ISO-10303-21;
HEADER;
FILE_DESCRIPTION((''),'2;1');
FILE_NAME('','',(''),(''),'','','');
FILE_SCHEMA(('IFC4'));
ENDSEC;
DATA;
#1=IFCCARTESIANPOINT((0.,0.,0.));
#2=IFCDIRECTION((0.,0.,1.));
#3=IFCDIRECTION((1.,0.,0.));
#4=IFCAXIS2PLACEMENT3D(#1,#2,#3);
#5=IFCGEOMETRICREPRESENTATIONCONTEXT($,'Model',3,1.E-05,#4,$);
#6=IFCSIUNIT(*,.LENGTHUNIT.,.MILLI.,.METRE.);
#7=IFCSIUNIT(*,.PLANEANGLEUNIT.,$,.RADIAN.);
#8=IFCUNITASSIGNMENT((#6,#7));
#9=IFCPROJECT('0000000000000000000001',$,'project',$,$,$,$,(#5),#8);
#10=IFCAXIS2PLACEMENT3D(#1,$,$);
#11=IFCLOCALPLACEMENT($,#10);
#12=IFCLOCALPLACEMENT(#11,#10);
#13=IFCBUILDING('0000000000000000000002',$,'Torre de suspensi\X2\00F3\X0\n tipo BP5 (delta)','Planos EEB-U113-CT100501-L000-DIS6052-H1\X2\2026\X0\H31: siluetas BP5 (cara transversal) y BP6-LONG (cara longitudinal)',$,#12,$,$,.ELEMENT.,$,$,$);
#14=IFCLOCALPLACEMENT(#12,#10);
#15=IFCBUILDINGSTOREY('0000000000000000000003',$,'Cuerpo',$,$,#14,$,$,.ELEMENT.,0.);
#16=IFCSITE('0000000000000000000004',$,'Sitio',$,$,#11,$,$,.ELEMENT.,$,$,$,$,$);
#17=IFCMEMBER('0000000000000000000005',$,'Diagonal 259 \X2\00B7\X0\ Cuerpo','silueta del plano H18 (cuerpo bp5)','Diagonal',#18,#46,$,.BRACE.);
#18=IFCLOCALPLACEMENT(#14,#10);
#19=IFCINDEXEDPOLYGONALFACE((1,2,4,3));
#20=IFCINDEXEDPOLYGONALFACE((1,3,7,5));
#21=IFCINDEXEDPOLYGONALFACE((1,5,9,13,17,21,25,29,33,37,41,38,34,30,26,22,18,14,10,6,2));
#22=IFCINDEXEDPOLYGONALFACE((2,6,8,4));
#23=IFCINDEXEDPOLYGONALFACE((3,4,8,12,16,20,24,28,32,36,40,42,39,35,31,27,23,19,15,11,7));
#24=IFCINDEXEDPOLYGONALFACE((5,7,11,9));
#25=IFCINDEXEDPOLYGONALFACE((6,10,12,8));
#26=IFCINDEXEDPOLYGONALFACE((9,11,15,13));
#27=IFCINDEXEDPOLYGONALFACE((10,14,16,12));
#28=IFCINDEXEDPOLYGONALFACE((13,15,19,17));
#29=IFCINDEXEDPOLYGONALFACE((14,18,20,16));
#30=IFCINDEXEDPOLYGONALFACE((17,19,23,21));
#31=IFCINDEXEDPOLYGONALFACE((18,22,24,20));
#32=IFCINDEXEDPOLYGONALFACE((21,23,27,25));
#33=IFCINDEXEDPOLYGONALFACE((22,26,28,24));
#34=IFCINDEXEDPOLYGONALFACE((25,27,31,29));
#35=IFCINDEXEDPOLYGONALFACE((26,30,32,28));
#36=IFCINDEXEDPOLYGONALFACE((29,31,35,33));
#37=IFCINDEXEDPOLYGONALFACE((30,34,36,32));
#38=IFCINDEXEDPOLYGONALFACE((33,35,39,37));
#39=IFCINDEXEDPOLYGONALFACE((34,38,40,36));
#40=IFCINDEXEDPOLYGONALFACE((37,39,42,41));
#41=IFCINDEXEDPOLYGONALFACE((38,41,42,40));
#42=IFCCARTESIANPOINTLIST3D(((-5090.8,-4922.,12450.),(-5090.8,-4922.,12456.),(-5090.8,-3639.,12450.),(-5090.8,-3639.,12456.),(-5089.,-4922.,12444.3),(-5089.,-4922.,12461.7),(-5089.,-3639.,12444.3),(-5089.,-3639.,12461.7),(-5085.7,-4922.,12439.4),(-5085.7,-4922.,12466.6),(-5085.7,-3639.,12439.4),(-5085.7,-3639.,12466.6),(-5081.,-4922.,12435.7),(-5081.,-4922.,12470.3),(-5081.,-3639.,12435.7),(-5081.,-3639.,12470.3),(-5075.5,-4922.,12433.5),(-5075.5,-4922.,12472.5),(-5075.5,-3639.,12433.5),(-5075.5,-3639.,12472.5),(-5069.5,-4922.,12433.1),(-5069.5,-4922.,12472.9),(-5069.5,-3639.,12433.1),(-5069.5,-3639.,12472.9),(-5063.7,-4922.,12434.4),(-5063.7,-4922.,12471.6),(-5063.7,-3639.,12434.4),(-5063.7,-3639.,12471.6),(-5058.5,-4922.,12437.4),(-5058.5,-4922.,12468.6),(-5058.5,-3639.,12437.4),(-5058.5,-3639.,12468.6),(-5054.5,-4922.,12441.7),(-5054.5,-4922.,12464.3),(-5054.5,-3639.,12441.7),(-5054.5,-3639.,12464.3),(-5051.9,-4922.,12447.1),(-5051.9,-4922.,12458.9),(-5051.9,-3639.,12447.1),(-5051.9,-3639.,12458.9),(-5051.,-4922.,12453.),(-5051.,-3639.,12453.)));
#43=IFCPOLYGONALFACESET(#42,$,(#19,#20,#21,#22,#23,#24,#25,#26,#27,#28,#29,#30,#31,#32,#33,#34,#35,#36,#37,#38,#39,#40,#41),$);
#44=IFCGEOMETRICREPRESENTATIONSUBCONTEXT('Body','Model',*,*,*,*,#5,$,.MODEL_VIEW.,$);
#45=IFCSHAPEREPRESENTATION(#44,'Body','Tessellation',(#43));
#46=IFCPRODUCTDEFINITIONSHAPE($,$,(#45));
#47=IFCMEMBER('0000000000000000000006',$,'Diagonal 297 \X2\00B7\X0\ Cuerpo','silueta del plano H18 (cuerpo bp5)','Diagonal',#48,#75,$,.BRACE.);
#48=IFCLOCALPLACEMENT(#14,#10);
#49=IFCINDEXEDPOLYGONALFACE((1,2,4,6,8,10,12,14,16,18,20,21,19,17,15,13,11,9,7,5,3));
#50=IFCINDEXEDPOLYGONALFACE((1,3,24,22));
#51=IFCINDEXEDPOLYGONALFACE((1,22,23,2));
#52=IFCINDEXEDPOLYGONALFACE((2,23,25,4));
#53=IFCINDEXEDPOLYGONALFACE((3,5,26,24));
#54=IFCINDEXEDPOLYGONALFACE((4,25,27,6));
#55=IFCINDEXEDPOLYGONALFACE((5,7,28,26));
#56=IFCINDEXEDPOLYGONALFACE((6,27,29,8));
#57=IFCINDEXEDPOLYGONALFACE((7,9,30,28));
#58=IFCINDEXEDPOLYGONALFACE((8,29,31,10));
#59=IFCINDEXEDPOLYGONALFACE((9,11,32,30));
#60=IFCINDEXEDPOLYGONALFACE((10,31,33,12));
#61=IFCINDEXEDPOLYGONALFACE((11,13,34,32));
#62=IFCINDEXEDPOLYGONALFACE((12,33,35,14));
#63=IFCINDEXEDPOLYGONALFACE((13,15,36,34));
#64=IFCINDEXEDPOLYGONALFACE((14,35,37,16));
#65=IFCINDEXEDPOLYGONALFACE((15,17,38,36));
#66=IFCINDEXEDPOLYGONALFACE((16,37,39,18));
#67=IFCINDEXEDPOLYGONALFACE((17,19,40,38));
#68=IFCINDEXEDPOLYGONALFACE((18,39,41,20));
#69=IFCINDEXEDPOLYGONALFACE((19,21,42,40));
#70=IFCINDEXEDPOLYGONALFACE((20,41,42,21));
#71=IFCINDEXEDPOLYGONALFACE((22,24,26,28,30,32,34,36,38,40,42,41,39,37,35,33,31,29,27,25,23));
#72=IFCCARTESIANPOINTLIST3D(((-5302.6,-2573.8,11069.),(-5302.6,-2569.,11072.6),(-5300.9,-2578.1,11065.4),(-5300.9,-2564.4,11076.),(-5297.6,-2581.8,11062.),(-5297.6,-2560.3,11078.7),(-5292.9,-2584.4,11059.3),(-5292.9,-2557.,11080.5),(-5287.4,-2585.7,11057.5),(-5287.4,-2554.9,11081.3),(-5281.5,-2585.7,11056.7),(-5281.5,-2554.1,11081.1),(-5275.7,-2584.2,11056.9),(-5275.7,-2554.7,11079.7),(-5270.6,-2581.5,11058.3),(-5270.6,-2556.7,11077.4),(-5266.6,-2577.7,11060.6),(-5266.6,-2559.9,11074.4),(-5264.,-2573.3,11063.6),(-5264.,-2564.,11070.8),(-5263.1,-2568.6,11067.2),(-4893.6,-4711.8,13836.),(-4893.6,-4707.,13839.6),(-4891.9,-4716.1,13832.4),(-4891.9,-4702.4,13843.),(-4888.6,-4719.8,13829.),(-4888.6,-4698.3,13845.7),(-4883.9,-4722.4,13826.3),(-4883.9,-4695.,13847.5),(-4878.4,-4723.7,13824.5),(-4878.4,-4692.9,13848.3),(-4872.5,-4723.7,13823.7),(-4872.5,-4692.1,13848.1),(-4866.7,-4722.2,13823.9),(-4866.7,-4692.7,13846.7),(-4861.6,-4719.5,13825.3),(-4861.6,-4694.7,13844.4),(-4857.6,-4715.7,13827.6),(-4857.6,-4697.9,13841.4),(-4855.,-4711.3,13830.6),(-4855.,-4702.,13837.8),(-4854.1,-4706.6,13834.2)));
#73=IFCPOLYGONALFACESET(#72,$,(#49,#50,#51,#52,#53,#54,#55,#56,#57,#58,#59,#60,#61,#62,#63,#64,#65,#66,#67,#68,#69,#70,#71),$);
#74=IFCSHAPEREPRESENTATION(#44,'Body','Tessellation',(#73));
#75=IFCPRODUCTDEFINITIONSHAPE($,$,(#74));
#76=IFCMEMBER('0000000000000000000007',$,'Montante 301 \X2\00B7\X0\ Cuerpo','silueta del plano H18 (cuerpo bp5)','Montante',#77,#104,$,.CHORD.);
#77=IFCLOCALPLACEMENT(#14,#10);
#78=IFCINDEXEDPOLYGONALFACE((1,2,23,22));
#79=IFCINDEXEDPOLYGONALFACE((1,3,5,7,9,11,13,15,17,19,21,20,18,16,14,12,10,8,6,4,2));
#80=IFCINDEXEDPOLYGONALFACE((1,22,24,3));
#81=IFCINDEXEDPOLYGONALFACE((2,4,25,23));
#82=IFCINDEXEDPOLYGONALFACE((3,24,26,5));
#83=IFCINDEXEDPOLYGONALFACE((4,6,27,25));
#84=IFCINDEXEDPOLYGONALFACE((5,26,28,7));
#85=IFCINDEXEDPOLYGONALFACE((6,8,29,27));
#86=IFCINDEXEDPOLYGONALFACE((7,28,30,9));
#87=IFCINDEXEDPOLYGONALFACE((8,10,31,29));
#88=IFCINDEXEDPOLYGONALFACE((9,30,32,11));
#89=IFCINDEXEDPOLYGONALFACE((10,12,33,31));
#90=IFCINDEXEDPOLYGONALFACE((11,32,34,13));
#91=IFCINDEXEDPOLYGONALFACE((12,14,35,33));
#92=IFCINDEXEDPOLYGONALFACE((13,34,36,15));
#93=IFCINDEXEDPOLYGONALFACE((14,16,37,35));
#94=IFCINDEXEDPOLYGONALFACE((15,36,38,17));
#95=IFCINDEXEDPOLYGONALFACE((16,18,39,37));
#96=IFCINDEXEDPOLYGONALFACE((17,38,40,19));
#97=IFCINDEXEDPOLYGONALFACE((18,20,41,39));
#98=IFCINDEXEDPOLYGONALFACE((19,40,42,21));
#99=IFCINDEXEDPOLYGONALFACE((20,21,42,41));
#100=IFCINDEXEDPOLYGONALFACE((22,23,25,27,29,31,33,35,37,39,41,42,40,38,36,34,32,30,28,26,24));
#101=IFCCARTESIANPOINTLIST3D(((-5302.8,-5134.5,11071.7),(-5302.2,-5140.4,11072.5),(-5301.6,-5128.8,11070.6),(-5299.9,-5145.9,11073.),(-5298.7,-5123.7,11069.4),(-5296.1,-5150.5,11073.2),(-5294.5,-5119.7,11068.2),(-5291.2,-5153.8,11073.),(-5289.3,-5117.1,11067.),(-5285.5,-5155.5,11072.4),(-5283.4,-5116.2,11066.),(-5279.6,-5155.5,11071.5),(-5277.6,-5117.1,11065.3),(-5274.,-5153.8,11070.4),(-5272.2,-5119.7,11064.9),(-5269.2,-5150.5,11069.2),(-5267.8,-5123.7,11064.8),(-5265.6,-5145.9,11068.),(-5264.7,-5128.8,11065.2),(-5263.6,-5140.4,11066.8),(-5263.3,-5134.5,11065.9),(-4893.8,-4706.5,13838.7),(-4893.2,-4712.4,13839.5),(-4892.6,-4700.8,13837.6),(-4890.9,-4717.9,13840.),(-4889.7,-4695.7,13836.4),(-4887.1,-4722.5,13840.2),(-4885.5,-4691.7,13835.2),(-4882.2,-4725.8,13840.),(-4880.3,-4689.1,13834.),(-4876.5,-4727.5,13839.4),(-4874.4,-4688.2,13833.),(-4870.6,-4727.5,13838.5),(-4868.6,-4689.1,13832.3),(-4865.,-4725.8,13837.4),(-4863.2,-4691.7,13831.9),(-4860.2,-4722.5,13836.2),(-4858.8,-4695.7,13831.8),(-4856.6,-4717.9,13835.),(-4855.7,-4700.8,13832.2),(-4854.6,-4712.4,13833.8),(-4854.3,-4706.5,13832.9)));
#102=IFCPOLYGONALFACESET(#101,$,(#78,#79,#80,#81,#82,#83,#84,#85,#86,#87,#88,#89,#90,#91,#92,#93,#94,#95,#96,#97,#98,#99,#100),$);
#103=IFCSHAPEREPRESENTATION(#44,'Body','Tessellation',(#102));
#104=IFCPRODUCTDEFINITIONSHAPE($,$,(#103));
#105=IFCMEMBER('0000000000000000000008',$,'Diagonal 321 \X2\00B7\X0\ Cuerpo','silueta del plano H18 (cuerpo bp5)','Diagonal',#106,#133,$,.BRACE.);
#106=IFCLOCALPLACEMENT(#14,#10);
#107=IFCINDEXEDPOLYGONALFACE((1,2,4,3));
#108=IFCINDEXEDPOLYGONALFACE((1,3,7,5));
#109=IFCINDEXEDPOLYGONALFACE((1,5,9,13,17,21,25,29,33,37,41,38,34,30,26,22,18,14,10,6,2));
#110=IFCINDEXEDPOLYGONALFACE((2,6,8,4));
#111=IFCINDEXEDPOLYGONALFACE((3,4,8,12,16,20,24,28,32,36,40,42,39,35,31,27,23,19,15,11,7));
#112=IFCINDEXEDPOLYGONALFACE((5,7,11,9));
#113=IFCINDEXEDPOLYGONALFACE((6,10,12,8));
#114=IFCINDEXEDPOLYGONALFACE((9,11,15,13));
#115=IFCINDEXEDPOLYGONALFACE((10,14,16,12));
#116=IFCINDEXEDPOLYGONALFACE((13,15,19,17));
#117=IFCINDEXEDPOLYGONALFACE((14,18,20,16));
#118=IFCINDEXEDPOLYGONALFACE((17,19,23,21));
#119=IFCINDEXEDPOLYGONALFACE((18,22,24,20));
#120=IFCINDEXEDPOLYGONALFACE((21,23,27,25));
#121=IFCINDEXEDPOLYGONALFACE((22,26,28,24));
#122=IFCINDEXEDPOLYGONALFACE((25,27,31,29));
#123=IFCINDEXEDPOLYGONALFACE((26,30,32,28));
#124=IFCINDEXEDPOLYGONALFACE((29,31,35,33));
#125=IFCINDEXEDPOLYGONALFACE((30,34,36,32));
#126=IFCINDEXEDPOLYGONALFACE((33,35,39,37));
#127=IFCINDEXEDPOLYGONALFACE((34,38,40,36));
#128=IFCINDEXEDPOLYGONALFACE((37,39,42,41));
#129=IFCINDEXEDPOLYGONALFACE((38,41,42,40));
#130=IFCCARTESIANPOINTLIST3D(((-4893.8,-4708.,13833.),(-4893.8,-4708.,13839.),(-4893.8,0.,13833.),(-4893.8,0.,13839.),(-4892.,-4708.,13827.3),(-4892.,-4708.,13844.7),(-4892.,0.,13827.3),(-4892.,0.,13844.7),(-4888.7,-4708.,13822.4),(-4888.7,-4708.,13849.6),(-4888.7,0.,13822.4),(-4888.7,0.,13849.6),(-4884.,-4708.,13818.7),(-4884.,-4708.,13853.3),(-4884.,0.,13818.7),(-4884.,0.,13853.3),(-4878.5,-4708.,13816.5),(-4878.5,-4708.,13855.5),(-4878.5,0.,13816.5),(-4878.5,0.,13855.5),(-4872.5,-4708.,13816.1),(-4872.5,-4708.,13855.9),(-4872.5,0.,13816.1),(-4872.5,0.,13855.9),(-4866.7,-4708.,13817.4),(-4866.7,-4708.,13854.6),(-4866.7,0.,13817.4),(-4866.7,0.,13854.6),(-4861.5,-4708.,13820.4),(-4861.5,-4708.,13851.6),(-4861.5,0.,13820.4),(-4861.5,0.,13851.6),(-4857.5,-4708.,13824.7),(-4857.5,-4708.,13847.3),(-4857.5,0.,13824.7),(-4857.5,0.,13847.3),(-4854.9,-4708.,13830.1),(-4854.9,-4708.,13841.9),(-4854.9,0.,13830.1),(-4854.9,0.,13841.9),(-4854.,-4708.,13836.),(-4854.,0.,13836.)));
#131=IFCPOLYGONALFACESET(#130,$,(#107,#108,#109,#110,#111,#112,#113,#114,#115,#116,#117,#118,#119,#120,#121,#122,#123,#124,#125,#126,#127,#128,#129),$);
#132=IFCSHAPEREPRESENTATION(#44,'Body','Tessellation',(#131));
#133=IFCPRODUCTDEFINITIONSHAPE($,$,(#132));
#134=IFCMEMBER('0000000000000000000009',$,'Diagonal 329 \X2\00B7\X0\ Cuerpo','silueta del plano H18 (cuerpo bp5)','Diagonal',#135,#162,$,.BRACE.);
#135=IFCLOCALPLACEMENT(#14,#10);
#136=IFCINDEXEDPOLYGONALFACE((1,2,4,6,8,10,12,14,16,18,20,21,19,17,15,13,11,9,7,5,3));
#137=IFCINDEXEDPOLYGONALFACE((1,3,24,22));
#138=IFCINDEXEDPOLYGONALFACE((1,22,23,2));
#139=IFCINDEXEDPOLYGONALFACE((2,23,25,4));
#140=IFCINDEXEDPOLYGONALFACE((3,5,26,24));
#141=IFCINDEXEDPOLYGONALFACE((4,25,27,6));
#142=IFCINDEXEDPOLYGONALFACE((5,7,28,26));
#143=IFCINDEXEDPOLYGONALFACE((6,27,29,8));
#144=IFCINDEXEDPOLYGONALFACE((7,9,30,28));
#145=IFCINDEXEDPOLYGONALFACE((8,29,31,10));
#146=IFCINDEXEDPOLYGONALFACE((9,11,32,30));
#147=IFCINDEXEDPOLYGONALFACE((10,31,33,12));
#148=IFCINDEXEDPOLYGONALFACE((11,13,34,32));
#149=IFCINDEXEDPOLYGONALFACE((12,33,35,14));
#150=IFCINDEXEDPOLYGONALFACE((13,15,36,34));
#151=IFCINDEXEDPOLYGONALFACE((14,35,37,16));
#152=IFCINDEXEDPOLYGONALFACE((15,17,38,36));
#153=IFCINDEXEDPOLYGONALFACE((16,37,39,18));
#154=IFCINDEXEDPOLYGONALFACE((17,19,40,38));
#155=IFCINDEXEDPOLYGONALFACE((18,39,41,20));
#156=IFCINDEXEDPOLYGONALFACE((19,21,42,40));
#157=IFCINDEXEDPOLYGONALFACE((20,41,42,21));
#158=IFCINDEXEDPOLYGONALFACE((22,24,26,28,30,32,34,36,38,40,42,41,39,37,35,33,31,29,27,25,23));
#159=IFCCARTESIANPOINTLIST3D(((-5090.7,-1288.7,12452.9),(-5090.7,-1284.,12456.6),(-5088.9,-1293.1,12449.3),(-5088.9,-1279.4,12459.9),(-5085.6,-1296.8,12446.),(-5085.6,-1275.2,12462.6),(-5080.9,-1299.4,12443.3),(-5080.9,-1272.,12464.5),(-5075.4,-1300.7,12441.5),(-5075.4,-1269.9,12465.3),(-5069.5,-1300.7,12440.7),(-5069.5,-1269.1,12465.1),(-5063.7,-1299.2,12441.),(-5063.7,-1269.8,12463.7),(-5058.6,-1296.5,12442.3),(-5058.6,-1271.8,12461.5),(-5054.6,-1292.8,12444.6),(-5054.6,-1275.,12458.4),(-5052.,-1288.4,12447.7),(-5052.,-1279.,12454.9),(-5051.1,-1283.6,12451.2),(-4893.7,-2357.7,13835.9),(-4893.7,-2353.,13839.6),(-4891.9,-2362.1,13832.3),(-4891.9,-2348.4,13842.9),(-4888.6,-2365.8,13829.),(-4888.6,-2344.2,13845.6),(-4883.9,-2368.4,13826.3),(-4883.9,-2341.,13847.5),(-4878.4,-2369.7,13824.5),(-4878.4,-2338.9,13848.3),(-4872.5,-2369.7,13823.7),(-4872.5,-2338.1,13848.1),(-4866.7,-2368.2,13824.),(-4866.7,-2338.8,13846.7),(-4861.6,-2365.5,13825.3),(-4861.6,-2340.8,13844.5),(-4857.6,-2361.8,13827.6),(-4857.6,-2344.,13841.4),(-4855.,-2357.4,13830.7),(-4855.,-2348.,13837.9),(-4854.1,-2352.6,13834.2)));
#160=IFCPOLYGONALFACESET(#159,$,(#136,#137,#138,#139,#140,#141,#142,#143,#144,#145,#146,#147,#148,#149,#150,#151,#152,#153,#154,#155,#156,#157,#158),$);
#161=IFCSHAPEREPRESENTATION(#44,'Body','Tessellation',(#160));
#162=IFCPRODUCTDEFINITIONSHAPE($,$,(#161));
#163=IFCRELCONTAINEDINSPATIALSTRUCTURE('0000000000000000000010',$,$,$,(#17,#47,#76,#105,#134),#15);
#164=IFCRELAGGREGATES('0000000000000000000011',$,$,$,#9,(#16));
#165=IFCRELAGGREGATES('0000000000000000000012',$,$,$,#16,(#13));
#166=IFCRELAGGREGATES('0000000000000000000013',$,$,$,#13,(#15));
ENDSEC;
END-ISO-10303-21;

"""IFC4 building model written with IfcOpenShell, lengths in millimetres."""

from ifc_helpers import new_model, si_unit, frame, origin, origin_with_axes, place, context, subcontext, project, spatial, circle, extrude, element, save


model = new_model("IFC4")

# Units and contexts
model_context = context("Model", 3, precision=1e-05, world=origin_with_axes())
body_context = subcontext(model_context, "Body", "Model", "MODEL_VIEW")
ifc_project = project(units=[si_unit("LENGTHUNIT", "METRE", prefix="MILLI"), si_unit("PLANEANGLEUNIT", "RADIAN")], contexts=[model_context])

# Site, building, storey
site_placement = place(None, origin())
site = spatial("IfcSite", under=ifc_project, at=site_placement, Name="Sitio", CompositionType="ELEMENT")
building_placement = place(site_placement, origin())
building = spatial("IfcBuilding", under=site, at=building_placement, Name="Torre de suspensión tipo BP5 (delta)", Description="Planos EEB-U113-CT100501-L000-DIS6052-H1…H31: siluetas BP5 (cara transversal) y BP6-LONG (cara longitudinal)", CompositionType="ELEMENT")
storey_placement = place(building_placement, origin())
storey = spatial("IfcBuildingStorey", under=building, at=storey_placement, Name="Cuerpo", CompositionType="ELEMENT", Elevation=0.0)

# Members
member_1_placement = place(storey_placement, frame((-5071.0, -4922.0, 12453.0), z_axis=(0.0, 1.0, 0.0), x_axis=(1.0, 0.0, 0.0)))
element("IfcMember", 1, at=member_1_placement, inside=storey, Name="Diagonal 259 · Cuerpo", Description="silueta del plano H18 (cuerpo bp5)", ObjectType="Diagonal", PredefinedType="BRACE", context=body_context, shape_type="SweptSolid", body=[
    extrude(circle(Radius=20.0), None, (0.0, 0.0, 1.0), 1283.0),
])
member_2_placement = place(storey_placement, frame((-4874.0, -4708.0, 13836.0), z_axis=(-0.116173, 0.607283, -0.785946), x_axis=(0.993229, 0.071031, -0.091928)))
element("IfcMember", 2, at=member_2_placement, inside=storey, Name="Diagonal 297 · Cuerpo", Description="silueta del plano H18 (cuerpo bp5)", ObjectType="Diagonal", PredefinedType="BRACE", context=body_context, shape_type="SweptSolid", body=[
    extrude(circle(Radius=20.0), None, (0.0, 0.0, 1.0), 3520.6),
])
member_3_placement = place(storey_placement, frame((-4874.0, -4708.0, 13836.0), z_axis=(-0.144542, -0.151257, -0.97787), x_axis=(-0.022118, 0.988494, -0.149631)))
element("IfcMember", 3, at=member_3_placement, inside=storey, Name="Montante 301 · Cuerpo", Description="silueta del plano H18 (cuerpo bp5)", ObjectType="Montante", PredefinedType="CHORD", context=body_context, shape_type="SweptSolid", body=[
    extrude(circle(Radius=20.0), None, (0.0, 0.0, 1.0), 2829.6),
])
member_4_placement = place(storey_placement, frame((-4874.0, -4708.0, 13836.0), z_axis=(0.0, 1.0, 0.0), x_axis=(1.0, 0.0, 0.0)))
element("IfcMember", 4, at=member_4_placement, inside=storey, Name="Diagonal 321 · Cuerpo", Description="silueta del plano H18 (cuerpo bp5)", ObjectType="Diagonal", PredefinedType="BRACE", context=body_context, shape_type="SweptSolid", body=[
    extrude(circle(Radius=20.0), None, (0.0, 0.0, 1.0), 4708.0),
])
member_5_placement = place(storey_placement, frame((-4874.0, -2354.0, 13836.0), z_axis=(-0.111992, 0.607714, -0.78622), x_axis=(0.993709, 0.06849, -0.088608)))
element("IfcMember", 5, at=member_5_placement, inside=storey, Name="Diagonal 329 · Cuerpo", Description="silueta del plano H18 (cuerpo bp5)", ObjectType="Diagonal", PredefinedType="BRACE", context=body_context, shape_type="SweptSolid", body=[
    extrude(circle(Radius=20.0), None, (0.0, 0.0, 1.0), 1759.1),
])

save(model, "model.ifc")
